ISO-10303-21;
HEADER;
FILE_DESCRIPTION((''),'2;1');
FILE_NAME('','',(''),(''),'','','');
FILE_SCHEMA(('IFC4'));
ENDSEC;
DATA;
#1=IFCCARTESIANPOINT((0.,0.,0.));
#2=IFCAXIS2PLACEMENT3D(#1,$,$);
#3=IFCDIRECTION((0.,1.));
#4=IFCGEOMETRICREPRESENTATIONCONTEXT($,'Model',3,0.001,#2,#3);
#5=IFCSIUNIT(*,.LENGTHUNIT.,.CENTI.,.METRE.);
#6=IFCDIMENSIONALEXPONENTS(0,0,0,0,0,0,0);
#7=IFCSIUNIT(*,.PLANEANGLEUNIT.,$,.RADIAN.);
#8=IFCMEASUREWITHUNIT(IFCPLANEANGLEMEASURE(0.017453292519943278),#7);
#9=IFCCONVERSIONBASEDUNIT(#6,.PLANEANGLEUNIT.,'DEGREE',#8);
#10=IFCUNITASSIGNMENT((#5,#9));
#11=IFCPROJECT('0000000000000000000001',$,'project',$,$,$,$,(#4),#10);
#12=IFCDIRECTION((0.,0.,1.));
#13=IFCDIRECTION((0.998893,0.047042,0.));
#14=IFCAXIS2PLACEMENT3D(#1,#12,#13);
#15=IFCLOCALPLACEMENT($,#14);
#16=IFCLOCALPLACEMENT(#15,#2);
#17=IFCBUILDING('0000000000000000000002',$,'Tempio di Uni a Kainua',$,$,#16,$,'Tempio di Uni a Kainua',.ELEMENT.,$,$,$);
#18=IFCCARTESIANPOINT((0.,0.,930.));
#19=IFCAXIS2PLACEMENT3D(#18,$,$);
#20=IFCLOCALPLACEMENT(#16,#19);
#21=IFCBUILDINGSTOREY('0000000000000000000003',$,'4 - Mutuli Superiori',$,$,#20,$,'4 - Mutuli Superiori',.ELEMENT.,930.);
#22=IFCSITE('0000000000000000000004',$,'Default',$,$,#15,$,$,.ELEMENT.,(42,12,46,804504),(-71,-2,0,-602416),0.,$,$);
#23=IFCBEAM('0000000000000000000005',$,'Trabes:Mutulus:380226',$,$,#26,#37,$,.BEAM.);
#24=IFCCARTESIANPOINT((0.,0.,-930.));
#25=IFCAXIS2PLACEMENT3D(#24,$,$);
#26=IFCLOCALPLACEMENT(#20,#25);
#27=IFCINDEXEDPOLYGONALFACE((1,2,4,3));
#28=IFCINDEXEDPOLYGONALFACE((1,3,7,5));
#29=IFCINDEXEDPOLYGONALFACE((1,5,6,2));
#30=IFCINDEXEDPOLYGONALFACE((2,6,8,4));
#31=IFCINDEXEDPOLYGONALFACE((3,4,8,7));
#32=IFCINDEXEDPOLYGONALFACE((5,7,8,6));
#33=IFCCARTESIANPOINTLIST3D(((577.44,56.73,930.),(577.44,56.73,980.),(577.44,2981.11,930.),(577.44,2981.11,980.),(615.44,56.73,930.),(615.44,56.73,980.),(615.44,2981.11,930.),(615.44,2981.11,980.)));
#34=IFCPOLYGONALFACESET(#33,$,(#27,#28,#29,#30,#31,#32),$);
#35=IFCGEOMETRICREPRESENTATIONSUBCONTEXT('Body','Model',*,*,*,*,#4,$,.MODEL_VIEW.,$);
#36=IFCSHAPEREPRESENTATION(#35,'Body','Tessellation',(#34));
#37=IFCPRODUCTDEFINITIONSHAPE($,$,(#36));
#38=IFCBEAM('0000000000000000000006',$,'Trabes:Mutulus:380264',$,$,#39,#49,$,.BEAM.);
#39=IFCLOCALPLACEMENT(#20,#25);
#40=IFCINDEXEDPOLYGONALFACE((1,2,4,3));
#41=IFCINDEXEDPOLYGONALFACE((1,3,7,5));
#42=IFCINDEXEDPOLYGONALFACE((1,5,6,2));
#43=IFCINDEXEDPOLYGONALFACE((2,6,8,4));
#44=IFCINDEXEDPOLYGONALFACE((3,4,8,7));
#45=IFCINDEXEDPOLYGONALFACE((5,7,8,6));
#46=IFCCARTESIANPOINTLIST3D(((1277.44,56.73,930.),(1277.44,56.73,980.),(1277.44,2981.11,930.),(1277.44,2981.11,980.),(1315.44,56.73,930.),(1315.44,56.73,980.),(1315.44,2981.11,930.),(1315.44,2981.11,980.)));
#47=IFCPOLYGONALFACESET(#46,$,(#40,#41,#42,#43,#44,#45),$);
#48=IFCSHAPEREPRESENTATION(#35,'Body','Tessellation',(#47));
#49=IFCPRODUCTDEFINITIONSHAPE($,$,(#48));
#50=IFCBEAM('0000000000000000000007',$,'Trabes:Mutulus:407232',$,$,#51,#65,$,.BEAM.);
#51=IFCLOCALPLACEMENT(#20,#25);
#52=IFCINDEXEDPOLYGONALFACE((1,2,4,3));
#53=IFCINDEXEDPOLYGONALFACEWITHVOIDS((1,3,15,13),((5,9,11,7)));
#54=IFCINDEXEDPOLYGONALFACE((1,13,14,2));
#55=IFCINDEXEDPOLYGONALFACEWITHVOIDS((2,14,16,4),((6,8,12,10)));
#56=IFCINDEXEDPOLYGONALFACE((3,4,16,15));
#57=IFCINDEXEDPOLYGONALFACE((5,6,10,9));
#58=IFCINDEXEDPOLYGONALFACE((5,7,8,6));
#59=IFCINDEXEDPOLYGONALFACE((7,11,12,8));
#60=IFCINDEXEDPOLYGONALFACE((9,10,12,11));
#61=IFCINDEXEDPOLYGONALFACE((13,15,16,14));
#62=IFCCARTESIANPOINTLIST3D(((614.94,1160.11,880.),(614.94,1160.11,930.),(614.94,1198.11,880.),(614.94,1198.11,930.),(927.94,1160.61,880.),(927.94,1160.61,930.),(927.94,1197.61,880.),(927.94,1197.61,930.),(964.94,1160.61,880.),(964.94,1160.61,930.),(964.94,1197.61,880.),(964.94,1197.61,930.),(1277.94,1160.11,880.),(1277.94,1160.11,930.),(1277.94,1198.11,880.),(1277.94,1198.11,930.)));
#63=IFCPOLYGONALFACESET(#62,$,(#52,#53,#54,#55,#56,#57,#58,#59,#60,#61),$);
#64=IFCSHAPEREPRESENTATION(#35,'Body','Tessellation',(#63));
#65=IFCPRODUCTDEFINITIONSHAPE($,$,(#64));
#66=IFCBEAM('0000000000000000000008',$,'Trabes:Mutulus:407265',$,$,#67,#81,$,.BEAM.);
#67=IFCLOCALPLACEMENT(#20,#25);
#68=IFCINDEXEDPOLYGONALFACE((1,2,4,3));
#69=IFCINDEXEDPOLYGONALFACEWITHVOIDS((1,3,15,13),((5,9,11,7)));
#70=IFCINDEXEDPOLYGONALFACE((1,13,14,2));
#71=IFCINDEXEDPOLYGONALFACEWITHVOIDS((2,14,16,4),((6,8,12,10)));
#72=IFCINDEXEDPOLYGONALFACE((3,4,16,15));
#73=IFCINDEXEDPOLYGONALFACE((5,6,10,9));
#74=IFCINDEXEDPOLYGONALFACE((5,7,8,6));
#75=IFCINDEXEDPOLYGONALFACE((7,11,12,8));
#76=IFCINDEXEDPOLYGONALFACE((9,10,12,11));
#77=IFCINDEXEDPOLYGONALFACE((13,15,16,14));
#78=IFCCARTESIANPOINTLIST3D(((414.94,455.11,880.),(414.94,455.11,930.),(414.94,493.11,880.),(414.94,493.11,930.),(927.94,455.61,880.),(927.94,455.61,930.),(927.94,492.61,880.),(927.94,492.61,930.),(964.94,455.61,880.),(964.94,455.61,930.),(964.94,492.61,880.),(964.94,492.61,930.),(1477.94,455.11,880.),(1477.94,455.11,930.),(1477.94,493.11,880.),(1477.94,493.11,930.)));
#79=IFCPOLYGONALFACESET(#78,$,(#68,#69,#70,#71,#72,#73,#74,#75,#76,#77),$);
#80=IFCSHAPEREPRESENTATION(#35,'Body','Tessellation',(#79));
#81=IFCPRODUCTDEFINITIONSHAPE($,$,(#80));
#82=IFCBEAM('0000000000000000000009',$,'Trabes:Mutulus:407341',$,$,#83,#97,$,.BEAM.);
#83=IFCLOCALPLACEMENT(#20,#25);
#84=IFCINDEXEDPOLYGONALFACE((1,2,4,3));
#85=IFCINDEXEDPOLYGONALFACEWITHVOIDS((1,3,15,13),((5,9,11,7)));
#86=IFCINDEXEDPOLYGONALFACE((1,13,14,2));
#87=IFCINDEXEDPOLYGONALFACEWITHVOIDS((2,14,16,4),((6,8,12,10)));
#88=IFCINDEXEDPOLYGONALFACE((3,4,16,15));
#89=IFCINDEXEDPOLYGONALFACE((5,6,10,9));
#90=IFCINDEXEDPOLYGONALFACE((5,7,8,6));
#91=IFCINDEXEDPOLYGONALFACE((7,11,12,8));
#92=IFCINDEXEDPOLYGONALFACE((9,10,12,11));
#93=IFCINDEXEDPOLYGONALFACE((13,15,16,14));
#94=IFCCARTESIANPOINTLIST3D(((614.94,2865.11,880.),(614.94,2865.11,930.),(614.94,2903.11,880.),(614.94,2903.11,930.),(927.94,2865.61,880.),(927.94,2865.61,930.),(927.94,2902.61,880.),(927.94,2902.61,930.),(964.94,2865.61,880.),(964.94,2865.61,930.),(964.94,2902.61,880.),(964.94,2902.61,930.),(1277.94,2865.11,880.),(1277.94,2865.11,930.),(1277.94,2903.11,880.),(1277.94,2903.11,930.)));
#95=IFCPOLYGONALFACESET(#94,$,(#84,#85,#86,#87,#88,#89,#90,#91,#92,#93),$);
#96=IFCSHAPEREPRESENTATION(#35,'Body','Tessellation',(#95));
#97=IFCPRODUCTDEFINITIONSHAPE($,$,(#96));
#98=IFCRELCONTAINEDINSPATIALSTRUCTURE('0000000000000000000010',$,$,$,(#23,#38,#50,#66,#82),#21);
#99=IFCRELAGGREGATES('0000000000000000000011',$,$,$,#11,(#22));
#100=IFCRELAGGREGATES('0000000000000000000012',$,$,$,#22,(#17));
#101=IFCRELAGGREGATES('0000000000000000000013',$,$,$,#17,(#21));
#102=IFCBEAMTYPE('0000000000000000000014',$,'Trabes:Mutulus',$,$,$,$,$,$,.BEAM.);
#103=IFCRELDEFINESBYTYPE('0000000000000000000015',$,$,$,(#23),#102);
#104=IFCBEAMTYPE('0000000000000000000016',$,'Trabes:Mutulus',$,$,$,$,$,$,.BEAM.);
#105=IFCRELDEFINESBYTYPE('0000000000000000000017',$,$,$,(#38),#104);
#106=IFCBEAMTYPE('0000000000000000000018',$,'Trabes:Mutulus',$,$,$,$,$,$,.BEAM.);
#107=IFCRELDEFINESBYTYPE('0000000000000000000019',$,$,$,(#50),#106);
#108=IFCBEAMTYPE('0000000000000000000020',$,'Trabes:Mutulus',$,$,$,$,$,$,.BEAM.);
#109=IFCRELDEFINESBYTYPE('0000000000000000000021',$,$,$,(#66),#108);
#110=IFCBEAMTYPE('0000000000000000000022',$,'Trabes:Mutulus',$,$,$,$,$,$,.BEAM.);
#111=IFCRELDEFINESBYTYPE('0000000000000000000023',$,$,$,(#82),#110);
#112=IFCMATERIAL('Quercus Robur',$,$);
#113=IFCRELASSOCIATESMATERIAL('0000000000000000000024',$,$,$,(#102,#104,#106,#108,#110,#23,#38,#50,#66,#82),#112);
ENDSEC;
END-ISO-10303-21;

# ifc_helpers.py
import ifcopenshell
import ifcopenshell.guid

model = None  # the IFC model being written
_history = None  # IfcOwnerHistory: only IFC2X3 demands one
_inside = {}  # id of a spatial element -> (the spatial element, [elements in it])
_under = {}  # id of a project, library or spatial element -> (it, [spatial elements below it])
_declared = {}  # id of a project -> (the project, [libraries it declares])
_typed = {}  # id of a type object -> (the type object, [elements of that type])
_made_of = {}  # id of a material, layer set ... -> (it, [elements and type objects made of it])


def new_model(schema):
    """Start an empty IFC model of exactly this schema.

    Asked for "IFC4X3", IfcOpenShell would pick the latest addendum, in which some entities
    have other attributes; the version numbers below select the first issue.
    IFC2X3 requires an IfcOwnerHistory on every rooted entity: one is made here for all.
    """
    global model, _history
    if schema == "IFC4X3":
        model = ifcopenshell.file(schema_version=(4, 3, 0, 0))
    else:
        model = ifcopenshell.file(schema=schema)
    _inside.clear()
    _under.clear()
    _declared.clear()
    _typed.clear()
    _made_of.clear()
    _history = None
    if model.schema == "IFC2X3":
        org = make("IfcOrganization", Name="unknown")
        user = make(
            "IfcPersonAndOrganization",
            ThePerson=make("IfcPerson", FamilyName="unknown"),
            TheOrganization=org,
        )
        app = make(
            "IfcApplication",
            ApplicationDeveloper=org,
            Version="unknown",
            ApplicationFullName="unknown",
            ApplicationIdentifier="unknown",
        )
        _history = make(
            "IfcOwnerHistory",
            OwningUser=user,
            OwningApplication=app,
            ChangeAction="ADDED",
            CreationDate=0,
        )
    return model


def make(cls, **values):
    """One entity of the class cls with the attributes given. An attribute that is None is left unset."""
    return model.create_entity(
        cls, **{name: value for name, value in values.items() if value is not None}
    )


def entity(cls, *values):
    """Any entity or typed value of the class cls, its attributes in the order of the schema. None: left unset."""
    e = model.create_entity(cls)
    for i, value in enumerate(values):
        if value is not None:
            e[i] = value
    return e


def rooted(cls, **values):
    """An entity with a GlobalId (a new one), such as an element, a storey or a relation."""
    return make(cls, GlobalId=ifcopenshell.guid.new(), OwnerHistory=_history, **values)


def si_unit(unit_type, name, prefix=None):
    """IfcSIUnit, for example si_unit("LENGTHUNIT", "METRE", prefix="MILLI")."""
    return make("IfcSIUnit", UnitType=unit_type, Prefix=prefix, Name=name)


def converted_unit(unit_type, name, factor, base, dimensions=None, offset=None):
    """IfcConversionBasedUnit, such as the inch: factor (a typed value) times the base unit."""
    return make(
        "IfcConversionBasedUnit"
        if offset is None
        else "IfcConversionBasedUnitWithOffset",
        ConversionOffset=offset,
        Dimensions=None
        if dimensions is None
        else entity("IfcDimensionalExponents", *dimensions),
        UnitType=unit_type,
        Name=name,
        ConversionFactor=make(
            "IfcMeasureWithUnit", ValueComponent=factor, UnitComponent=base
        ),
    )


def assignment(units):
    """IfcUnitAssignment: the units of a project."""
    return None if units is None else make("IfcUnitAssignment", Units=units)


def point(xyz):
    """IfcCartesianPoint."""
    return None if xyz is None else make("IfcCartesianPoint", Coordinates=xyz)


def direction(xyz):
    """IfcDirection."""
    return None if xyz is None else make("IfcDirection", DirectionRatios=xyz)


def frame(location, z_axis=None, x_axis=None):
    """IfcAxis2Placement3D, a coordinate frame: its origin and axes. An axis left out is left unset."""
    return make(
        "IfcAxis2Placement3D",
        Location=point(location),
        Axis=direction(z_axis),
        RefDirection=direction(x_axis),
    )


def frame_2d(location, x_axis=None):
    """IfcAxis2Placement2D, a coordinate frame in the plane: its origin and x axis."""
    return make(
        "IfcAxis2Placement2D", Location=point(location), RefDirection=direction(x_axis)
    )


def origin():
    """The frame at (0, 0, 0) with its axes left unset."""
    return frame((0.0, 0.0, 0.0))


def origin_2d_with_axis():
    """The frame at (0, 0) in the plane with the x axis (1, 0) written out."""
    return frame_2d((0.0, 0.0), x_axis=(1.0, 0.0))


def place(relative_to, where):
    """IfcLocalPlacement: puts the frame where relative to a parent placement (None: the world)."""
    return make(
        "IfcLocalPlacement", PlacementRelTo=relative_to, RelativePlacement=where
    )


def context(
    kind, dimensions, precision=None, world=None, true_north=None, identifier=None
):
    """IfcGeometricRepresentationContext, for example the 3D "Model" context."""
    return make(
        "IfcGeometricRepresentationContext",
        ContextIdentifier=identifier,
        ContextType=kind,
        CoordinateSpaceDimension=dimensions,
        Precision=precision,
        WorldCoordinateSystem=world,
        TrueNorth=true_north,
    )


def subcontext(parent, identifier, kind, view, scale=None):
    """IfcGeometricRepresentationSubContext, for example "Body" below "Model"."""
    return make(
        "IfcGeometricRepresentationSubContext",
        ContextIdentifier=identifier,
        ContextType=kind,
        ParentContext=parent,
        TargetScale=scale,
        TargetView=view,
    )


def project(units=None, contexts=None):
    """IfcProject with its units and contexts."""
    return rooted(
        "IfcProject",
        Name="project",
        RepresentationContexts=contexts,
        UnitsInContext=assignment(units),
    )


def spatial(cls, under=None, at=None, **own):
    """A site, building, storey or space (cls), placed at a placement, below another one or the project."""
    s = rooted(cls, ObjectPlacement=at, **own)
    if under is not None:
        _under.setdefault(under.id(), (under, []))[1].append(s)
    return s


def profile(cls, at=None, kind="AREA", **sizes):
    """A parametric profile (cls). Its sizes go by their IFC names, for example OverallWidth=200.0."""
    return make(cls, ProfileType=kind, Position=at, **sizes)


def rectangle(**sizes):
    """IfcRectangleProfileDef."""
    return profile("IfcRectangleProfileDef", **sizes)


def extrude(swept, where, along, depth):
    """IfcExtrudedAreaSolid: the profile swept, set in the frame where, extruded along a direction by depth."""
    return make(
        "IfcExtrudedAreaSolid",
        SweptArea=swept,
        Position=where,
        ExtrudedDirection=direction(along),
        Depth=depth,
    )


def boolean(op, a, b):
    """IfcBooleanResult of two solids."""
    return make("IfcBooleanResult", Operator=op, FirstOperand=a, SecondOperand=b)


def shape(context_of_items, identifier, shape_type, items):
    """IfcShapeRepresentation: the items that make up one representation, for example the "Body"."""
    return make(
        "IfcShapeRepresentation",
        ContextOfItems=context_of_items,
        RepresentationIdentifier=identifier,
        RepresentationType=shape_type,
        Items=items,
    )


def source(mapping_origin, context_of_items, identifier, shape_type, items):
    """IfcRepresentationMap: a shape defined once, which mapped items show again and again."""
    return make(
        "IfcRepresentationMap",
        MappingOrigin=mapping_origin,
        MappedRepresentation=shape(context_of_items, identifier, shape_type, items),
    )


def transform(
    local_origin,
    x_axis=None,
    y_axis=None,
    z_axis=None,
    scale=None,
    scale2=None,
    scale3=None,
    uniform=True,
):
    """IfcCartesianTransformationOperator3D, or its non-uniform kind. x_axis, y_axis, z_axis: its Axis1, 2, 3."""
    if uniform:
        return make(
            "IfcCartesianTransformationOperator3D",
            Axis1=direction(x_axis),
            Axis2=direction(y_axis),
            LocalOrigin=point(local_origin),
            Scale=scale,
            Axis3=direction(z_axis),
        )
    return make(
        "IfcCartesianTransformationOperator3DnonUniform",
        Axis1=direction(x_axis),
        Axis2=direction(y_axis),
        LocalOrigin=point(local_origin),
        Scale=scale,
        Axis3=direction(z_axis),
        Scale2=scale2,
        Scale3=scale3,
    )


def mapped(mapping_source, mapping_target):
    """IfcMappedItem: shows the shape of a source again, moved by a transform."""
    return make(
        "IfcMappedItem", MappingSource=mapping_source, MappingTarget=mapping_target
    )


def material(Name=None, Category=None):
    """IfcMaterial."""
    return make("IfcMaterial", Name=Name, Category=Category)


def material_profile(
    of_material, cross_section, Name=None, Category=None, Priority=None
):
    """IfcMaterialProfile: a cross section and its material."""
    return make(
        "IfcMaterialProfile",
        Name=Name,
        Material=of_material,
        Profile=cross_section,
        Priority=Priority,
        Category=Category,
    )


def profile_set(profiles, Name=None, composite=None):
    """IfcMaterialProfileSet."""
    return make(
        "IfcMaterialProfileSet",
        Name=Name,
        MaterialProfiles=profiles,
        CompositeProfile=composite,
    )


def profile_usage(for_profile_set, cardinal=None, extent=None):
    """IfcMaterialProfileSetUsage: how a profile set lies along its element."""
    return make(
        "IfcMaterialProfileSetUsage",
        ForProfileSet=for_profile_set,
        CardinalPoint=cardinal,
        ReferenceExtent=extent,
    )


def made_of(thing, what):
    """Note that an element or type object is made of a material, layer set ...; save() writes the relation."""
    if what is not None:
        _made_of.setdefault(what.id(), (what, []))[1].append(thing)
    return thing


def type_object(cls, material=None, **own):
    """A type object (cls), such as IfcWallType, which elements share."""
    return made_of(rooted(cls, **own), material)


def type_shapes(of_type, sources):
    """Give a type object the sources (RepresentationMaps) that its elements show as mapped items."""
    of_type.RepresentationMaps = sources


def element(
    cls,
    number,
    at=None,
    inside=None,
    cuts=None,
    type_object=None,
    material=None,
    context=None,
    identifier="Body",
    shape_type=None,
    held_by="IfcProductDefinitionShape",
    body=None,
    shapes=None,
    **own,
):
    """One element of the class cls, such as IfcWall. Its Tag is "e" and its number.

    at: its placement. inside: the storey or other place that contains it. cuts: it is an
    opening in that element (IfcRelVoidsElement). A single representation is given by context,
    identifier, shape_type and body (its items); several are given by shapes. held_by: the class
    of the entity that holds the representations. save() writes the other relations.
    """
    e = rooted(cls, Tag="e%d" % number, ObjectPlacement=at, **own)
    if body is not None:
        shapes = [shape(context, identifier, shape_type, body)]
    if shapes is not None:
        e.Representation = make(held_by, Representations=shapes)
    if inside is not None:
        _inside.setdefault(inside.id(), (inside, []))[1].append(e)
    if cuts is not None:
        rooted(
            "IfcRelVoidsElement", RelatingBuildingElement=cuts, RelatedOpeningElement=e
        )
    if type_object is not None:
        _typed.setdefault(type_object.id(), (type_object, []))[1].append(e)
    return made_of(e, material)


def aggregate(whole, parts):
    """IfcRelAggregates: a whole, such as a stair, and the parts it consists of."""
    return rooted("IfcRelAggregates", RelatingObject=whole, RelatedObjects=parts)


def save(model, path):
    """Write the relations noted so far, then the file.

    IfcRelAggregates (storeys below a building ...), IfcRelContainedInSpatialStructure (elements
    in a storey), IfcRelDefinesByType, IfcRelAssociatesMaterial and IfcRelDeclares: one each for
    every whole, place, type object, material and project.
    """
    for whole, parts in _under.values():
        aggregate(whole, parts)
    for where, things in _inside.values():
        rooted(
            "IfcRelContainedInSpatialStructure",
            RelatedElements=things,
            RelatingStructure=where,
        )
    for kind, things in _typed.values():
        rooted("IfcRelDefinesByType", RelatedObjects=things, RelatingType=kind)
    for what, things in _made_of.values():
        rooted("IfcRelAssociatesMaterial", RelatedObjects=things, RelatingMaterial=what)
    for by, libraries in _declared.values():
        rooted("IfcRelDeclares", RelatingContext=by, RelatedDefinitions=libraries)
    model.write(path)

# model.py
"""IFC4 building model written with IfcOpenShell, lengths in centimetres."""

from ifc_helpers import new_model, entity, si_unit, converted_unit, direction, frame, frame_2d, origin, origin_2d_with_axis, place, context, subcontext, project, spatial, rectangle, extrude, boolean, source, transform, mapped, material, material_profile, profile_set, profile_usage, type_object, type_shapes, element, save


model = new_model("IFC4")

# Units and contexts
model_context = context("Model", 3, precision=0.001, world=origin(), true_north=direction((0.0, 1.0)))
body_context = subcontext(model_context, "Body", "Model", "MODEL_VIEW")
ifc_project = project(units=[si_unit("LENGTHUNIT", "METRE", prefix="CENTI"), converted_unit("PLANEANGLEUNIT", "DEGREE", entity("IfcPlaneAngleMeasure", 0.017453292519943278), si_unit("PLANEANGLEUNIT", "RADIAN"), dimensions=[0, 0, 0, 0, 0, 0, 0])], contexts=[model_context])

# Site, building, storey
site_placement = place(None, frame((0.0, 0.0, 0.0), z_axis=(0.0, 0.0, 1.0), x_axis=(0.998893, 0.047042, 0.0)))
site = spatial("IfcSite", under=ifc_project, at=site_placement, Name="Default", CompositionType="ELEMENT", RefLatitude=(42, 12, 46, 804504), RefLongitude=(-71, -2, 0, -602416), RefElevation=0.0)
building_placement = place(site_placement, origin())
building = spatial("IfcBuilding", under=site, at=building_placement, Name="Tempio di Uni a Kainua", LongName="Tempio di Uni a Kainua", CompositionType="ELEMENT")
storey_placement = place(building_placement, frame((0.0, 0.0, 930.0)))
storey = spatial("IfcBuildingStorey", under=building, at=storey_placement, Name="4 - Mutuli Superiori", LongName="4 - Mutuli Superiori", CompositionType="ELEMENT", Elevation=930.0)

# Beams
ifc_material = material(Name="Quercus Robur")
ifc_material_profile = material_profile(ifc_material, rectangle(XDim=2814.5, YDim=38.0, at=origin_2d_with_axis()), Name="Mutulus")
ifc_profile_set = profile_set([ifc_material_profile], Name="Mutulus")
ifc_profile_usage_1 = profile_usage(ifc_profile_set, cardinal=2)
beam_type_1 = type_object("IfcBeamType", Name="Trabes:Mutulus", PredefinedType="BEAM", material=ifc_profile_set)
shared_shape_1 = source(origin(), body_context, "Body", "SweptSolid", [
    extrude(rectangle(XDim=50.0, YDim=38.0, at=frame_2d((0.0, 0.0), x_axis=(0.0, 1.0))), frame((596.44, 2981.11, 955.0), z_axis=(0.0, -1.0, 0.0), x_axis=(-1.0, 0.0, 0.0)), (0.0, 0.0, 1.0), 2924.37),
])
type_shapes(beam_type_1, [shared_shape_1])
beam_1_placement = place(storey_placement, frame((0.0, 0.0, -930.0)))
element("IfcBeam", 1, at=beam_1_placement, inside=storey, type_object=beam_type_1, material=ifc_profile_usage_1, Name="Trabes:Mutulus:380226", PredefinedType="BEAM", context=body_context, shape_type="MappedRepresentation", body=[
    mapped(shared_shape_1, transform((0.0, 0.0, 0.0), scale=1.0)),
])
beam_type_2 = type_object("IfcBeamType", Name="Trabes:Mutulus", PredefinedType="BEAM", material=ifc_profile_set)
shared_shape_2 = source(origin(), body_context, "Body", "SweptSolid", [
    extrude(rectangle(XDim=50.0, YDim=38.0, at=frame_2d((0.0, 0.0), x_axis=(0.0, 1.0))), frame((1296.44, 2981.11, 955.0), z_axis=(0.0, -1.0, 0.0), x_axis=(-1.0, 0.0, 0.0)), (0.0, 0.0, 1.0), 2924.37),
])
type_shapes(beam_type_2, [shared_shape_2])
beam_2_placement = place(storey_placement, frame((0.0, 0.0, -930.0)))
element("IfcBeam", 2, at=beam_2_placement, inside=storey, type_object=beam_type_2, material=ifc_profile_usage_1, Name="Trabes:Mutulus:380264", PredefinedType="BEAM", context=body_context, shape_type="MappedRepresentation", body=[
    mapped(shared_shape_2, transform((0.0, 0.0, 0.0), scale=1.0)),
])
beam_type_3 = type_object("IfcBeamType", Name="Trabes:Mutulus", PredefinedType="BEAM", material=ifc_profile_set)
shared_shape_3 = source(origin(), body_context, "Body", "CSG", [
    boolean("DIFFERENCE", extrude(rectangle(XDim=50.0, YDim=38.0, at=frame_2d((0.0, 0.0), x_axis=(1.0, 0.0))), frame((614.94, 1179.11, 905.0), z_axis=(1.0, 0.0, 0.0), x_axis=(0.0, 0.0, -1.0)), (0.0, 0.0, 1.0), 663.0), extrude(rectangle(XDim=37.0, YDim=37.0, at=frame_2d((0.0, 0.0), x_axis=(1.0, 0.0))), frame((946.44, 1179.11, 880.0), z_axis=(0.0, 0.0, 1.0), x_axis=(0.0, 1.0, 0.0)), (0.0, 0.0, 1.0), 50.0)),
])
type_shapes(beam_type_3, [shared_shape_3])
beam_3_placement = place(storey_placement, frame((0.0, 0.0, -930.0)))
element("IfcBeam", 3, at=beam_3_placement, inside=storey, type_object=beam_type_3, material=ifc_material, Name="Trabes:Mutulus:407232", PredefinedType="BEAM", context=body_context, shape_type="MappedRepresentation", body=[
    mapped(shared_shape_3, transform((0.0, 0.0, 0.0), scale=1.0)),
])
beam_type_4 = type_object("IfcBeamType", Name="Trabes:Mutulus", PredefinedType="BEAM", material=ifc_profile_set)
shared_shape_4 = source(origin(), body_context, "Body", "CSG", [
    boolean("DIFFERENCE", extrude(rectangle(XDim=50.0, YDim=38.0, at=frame_2d((0.0, 0.0), x_axis=(1.0, 0.0))), frame((414.94, 474.11, 905.0), z_axis=(1.0, 0.0, 0.0), x_axis=(0.0, 0.0, -1.0)), (0.0, 0.0, 1.0), 1063.0), extrude(rectangle(XDim=37.0, YDim=37.0, at=frame_2d((0.0, 0.0), x_axis=(1.0, 0.0))), frame((946.44, 474.11, 880.0), z_axis=(0.0, 0.0, 1.0), x_axis=(0.0, 1.0, 0.0)), (0.0, 0.0, 1.0), 50.0)),
])
type_shapes(beam_type_4, [shared_shape_4])
beam_4_placement = place(storey_placement, frame((0.0, 0.0, -930.0)))
element("IfcBeam", 4, at=beam_4_placement, inside=storey, type_object=beam_type_4, material=ifc_material, Name="Trabes:Mutulus:407265", PredefinedType="BEAM", context=body_context, shape_type="MappedRepresentation", body=[
    mapped(shared_shape_4, transform((0.0, 0.0, 0.0), scale=1.0)),
])
beam_type_5 = type_object("IfcBeamType", Name="Trabes:Mutulus", PredefinedType="BEAM", material=ifc_profile_set)
shared_shape_5 = source(origin(), body_context, "Body", "CSG", [
    boolean("DIFFERENCE", extrude(rectangle(XDim=50.0, YDim=38.0, at=frame_2d((0.0, 0.0), x_axis=(1.0, 0.0))), frame((614.94, 2884.11, 905.0), z_axis=(1.0, 0.0, 0.0), x_axis=(0.0, 0.0, -1.0)), (0.0, 0.0, 1.0), 663.0), extrude(rectangle(XDim=37.0, YDim=37.0, at=frame_2d((0.0, 0.0), x_axis=(1.0, 0.0))), frame((946.44, 2884.11, 880.0), z_axis=(0.0, 0.0, 1.0), x_axis=(0.0, 1.0, 0.0)), (0.0, 0.0, 1.0), 50.0)),
])
type_shapes(beam_type_5, [shared_shape_5])
beam_5_placement = place(storey_placement, frame((0.0, 0.0, -930.0)))
element("IfcBeam", 5, at=beam_5_placement, inside=storey, type_object=beam_type_5, material=ifc_material, Name="Trabes:Mutulus:407341", PredefinedType="BEAM", context=body_context, shape_type="MappedRepresentation", body=[
    mapped(shared_shape_5, transform((0.0, 0.0, 0.0), scale=1.0)),
])

save(model, "model.ifc")
